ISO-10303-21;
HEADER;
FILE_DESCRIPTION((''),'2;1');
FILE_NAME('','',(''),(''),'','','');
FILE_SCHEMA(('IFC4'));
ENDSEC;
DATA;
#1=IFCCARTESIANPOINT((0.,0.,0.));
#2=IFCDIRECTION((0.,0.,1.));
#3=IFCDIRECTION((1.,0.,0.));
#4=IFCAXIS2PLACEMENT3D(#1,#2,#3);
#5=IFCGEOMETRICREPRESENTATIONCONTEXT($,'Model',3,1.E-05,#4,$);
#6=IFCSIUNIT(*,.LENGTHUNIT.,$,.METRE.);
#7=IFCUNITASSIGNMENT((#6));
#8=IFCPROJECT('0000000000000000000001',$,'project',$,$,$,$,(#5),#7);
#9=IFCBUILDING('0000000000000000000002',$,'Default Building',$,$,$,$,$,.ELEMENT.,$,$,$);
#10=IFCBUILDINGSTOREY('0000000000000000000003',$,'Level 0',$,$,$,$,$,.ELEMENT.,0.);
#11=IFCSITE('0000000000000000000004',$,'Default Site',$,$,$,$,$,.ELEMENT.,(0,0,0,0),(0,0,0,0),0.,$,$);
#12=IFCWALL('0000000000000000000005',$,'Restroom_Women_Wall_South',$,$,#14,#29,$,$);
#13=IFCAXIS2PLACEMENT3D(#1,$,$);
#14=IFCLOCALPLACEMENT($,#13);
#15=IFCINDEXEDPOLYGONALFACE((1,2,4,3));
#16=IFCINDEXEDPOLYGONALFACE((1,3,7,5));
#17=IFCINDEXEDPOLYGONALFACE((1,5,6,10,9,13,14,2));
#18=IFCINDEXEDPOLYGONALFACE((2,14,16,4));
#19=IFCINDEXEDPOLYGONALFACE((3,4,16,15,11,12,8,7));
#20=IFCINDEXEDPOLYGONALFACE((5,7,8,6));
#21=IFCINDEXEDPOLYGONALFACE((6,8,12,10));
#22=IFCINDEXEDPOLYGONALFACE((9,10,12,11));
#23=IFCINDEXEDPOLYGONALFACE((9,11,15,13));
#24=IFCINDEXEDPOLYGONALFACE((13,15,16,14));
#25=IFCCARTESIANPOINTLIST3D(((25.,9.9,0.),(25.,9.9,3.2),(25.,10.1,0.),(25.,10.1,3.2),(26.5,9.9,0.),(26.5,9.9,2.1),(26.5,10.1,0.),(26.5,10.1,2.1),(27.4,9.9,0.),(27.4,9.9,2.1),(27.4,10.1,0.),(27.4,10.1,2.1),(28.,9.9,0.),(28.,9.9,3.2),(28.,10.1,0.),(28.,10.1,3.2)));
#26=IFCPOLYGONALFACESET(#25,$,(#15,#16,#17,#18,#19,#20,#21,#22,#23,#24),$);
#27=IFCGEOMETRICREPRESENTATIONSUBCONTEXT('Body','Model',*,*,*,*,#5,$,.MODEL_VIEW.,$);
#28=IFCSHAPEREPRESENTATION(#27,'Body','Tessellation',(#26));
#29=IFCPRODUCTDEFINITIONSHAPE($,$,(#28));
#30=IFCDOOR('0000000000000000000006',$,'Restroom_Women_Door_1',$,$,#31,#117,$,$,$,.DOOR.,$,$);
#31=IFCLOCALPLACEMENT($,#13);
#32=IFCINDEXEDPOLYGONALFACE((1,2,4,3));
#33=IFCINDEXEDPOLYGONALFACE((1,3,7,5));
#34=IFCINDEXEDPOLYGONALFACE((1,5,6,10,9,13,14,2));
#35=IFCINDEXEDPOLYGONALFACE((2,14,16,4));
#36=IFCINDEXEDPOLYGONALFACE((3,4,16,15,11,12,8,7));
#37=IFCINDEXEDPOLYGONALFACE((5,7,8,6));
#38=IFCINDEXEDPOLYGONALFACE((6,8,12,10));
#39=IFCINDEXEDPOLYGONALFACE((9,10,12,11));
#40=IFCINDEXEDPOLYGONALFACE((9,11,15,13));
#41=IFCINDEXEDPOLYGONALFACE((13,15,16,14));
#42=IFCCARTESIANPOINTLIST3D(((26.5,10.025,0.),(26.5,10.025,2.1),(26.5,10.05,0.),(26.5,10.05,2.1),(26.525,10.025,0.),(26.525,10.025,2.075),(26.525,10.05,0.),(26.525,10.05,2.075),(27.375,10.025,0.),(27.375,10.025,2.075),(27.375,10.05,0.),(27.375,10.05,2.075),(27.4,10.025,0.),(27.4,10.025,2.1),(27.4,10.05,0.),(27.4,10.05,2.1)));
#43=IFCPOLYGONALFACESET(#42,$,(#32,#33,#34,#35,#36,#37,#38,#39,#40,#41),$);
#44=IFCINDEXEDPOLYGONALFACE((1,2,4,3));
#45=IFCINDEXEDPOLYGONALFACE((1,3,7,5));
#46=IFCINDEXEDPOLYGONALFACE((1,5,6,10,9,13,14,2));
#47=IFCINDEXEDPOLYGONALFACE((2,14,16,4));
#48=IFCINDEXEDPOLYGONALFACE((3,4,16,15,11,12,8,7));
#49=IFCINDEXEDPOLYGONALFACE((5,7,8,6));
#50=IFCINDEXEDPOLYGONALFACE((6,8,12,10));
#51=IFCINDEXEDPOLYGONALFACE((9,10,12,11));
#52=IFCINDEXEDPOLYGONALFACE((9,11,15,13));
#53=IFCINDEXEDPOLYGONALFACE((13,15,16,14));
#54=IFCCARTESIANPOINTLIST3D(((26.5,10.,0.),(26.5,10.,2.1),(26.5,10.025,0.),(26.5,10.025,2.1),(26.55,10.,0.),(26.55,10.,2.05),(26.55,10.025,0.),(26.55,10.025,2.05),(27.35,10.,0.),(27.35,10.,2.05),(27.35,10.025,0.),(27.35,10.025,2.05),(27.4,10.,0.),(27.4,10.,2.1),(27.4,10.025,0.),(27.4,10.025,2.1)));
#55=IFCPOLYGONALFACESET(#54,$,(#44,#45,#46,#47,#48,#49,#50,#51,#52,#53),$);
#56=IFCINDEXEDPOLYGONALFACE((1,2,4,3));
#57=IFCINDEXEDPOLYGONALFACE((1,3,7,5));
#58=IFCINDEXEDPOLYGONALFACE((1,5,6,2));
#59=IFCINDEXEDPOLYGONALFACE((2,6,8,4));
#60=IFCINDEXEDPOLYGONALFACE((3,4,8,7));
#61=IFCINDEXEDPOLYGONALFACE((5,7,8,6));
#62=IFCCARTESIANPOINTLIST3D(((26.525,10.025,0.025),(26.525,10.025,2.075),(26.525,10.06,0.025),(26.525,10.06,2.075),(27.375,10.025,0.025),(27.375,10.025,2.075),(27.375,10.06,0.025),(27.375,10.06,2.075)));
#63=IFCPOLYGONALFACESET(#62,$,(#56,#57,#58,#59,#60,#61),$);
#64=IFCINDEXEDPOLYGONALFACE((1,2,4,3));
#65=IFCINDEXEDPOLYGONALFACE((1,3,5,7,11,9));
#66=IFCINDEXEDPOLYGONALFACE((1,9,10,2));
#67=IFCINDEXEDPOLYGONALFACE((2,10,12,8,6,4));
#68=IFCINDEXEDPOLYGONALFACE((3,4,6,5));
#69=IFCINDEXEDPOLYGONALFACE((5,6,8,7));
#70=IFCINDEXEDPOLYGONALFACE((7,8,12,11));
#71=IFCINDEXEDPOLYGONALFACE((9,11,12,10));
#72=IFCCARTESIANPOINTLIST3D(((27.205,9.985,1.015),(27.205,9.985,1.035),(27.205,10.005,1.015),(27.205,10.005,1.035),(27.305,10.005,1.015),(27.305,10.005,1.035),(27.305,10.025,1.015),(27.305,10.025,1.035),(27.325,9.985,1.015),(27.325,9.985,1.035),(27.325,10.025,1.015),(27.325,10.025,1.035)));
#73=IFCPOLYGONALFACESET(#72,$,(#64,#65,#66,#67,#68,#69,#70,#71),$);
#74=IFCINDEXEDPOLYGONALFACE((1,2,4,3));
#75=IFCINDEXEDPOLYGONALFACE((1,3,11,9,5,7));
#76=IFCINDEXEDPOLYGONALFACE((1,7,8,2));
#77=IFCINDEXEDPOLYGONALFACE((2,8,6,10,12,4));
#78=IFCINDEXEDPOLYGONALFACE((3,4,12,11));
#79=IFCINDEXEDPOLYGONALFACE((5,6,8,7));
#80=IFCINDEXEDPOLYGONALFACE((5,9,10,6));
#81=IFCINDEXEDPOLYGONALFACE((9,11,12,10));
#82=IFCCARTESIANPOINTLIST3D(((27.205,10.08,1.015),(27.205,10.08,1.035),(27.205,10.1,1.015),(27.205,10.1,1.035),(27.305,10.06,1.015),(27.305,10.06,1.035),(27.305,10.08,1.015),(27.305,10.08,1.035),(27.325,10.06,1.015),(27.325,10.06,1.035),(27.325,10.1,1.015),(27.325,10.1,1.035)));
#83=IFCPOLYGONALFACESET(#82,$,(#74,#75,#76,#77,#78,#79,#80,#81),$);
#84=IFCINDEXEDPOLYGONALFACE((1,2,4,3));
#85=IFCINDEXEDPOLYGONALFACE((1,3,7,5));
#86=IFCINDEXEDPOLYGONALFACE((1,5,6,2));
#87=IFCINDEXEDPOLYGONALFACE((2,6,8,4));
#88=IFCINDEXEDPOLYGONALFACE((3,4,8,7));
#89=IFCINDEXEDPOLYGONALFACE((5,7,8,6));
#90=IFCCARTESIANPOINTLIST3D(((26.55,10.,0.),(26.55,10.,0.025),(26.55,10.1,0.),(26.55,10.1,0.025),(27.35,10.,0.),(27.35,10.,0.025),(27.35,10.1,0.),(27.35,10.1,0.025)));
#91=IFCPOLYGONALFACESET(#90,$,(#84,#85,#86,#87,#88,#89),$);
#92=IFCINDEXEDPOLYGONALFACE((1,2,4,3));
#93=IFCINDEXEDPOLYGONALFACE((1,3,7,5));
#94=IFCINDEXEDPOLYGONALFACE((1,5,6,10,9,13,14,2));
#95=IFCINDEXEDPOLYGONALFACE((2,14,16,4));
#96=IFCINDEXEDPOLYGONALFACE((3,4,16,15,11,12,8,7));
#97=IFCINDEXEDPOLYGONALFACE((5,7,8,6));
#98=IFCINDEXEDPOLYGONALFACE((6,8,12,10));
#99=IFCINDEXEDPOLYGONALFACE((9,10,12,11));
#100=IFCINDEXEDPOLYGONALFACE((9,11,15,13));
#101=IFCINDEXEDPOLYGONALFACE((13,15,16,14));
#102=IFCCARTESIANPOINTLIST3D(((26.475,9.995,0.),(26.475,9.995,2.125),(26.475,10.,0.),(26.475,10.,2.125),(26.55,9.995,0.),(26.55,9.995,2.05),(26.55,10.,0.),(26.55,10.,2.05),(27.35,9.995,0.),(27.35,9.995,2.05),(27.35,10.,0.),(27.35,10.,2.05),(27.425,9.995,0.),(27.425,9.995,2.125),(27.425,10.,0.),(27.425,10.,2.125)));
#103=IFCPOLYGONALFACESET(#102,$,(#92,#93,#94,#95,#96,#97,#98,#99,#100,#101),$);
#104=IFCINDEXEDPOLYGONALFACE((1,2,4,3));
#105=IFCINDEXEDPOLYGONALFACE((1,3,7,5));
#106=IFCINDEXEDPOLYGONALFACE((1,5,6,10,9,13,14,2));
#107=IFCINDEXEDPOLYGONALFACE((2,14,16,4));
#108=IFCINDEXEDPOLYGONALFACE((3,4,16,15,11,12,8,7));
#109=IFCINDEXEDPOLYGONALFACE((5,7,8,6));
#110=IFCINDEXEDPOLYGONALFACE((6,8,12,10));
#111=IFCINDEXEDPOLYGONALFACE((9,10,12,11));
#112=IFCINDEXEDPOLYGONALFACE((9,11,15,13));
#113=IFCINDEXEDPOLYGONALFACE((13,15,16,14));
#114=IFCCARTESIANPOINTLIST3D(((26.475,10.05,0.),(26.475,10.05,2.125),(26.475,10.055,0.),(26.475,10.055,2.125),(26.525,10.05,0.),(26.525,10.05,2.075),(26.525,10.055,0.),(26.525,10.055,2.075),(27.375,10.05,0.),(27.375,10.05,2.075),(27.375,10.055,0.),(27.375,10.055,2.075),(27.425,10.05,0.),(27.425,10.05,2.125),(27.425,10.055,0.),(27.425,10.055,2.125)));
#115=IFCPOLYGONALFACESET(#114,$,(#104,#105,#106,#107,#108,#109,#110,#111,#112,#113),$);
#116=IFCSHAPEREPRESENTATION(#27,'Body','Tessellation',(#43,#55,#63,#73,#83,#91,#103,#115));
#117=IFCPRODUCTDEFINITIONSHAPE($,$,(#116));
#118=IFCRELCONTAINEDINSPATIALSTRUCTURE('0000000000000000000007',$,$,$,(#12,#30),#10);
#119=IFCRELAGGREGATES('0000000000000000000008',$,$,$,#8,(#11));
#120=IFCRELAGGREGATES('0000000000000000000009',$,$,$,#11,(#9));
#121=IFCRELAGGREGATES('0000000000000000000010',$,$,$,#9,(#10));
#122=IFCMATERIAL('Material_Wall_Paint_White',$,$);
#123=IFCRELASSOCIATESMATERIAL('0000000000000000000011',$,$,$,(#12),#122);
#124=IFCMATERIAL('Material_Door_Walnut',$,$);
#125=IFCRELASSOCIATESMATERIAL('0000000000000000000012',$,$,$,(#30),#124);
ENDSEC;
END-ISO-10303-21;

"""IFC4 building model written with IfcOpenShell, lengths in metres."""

from ifc_helpers import new_model, si_unit, frame, origin_with_axes, place, context, subcontext, project, spatial, line, indexed_curve, outline, extrude, material, element, fill, save


model = new_model("IFC4")

# Units and contexts
model_context = context("Model", 3, precision=1e-05, world=origin_with_axes())
body_context = subcontext(model_context, "Body", "Model", "MODEL_VIEW")
ifc_project = project(units=[si_unit("LENGTHUNIT", "METRE")], contexts=[model_context])

# Site, building, storey
site = spatial("IfcSite", under=ifc_project, Name="Default Site", CompositionType="ELEMENT", RefLatitude=(0, 0, 0, 0), RefLongitude=(0, 0, 0, 0), RefElevation=0.0)
building = spatial("IfcBuilding", under=site, Name="Default Building", CompositionType="ELEMENT")
storey = spatial("IfcBuildingStorey", under=building, Name="Level 0", CompositionType="ELEMENT", Elevation=0.0)

# Shared definitions
ifc_material_1 = material(Name="Material_Wall_Paint_White")

# Shared definitions
ifc_material_2 = material(Name="Material_Door_Walnut")

# Wall, opening, door
wall_1_placement = place(None, frame((25.0, 10.0, 0.0), z_axis=(0.0, 0.0, 1.0), x_axis=(1.0, 0.0, 0.0)))
wall_1 = element("IfcWall", 1, at=wall_1_placement, inside=storey, material=ifc_material_1, Name="Restroom_Women_Wall_South", context=body_context, shape_type="SweptSolid", body=[
    extrude(outline(indexed_curve([(0.0, 0.0), (0.0, 0.2), (3.0, 0.2), (3.0, 0.0), (0.0, 0.0)], self_intersect=False)), frame((0.0, -0.1, 0.0), z_axis=(0.0, 0.0, 1.0), x_axis=(1.0, 0.0, 0.0)), (0.0, 0.0, 1.0), 3.2),
])
opening_1_placement = place(wall_1_placement, frame((1.5, -0.5, 0.0), z_axis=(0.0, 0.0, 1.0), x_axis=(1.0, 0.0, 0.0)))
opening_1 = element("IfcOpeningElement", 2, at=opening_1_placement, inside=storey, cuts=wall_1, PredefinedType="OPENING", context=body_context, shape_type="SweptSolid", body=[
    extrude(outline(indexed_curve([(0.0, 0.0), (0.0, 1.0), (0.9, 1.0), (0.9, 0.0), (0.0, 0.0)], self_intersect=False)), origin_with_axes(), (0.0, 0.0, 1.0), 2.1),
])
door_1_placement = place(None, frame((26.5, 10.0, 0.0), z_axis=(0.0, 0.0, 1.0), x_axis=(1.0, 0.0, 0.0)))
door_1 = element("IfcDoor", 3, at=door_1_placement, inside=storey, material=ifc_material_2, Name="Restroom_Women_Door_1", PredefinedType="DOOR", context=body_context, shape_type="SweptSolid", body=[
    extrude(outline(indexed_curve([(0.0, 0.0), (0.0, 2.1), (0.9, 2.1), (0.9, 0.0), (0.875, 0.0), (0.875, 2.075), (0.025, 2.075), (0.025, 0.0)], segments=[line(1, 2, 3, 4, 5, 6, 7, 8, 1)])), frame((0.0, 0.025, 0.0), z_axis=(0.0, -1.0, 0.0), x_axis=(1.0, 0.0, 0.0)), (0.0, 0.0, -1.0), 0.025),
    extrude(outline(indexed_curve([(0.0, 0.0), (0.0, 2.1), (0.9, 2.1), (0.9, 0.0), (0.85, 0.0), (0.85, 2.05), (0.05, 2.05), (0.05, 0.0)], segments=[line(1, 2, 3, 4, 5, 6, 7, 8, 1)])), frame((0.0, 0.0, 0.0), z_axis=(0.0, -1.0, 0.0), x_axis=(1.0, 0.0, 0.0)), (0.0, 0.0, -1.0), 0.025),
    extrude(outline(indexed_curve([(0.0, 0.0), (0.85, 0.0), (0.85, 0.035), (0.0, 0.035)], segments=[line(1, 2, 3, 4, 1)])), frame((0.025, 0.025, 0.025), z_axis=(0.0, 0.0, 1.0), x_axis=(1.0, 0.0, 0.0)), (0.0, 0.0, 1.0), 2.05),
    extrude(outline(indexed_curve([(0.0, 0.0), (0.0, -0.04), (-0.12, -0.04), (-0.12, -0.02), (-0.02, -0.02), (-0.02, 0.0)], segments=[line(1, 2, 3, 4, 5, 6, 1)])), frame((0.825, 0.025, 1.015), z_axis=(0.0, 0.0, 1.0), x_axis=(1.0, 0.0, 0.0)), (0.0, 0.0, 1.0), 0.02),
    extrude(outline(indexed_curve([(0.0, 0.0), (0.0, 0.04), (-0.12, 0.04), (-0.12, 0.02), (-0.02, 0.02), (-0.02, 0.0)], segments=[line(1, 2, 3, 4, 5, 6, 1)])), frame((0.825, 0.06, 1.015), z_axis=(0.0, 0.0, 1.0), x_axis=(1.0, 0.0, 0.0)), (0.0, 0.0, 1.0), 0.02),
    extrude(outline(indexed_curve([(0.0, 0.0), (0.8, 0.0), (0.8, 0.1), (0.0, 0.1)], segments=[line(1, 2, 3, 4, 1)])), frame((0.05, 0.0, 0.0), z_axis=(0.0, 0.0, 1.0), x_axis=(1.0, 0.0, 0.0)), (0.0, 0.0, 1.0), 0.025),
    extrude(outline(indexed_curve([(0.0, 0.0), (0.0, 2.125), (0.95, 2.125), (0.95, 0.0), (0.875, 0.0), (0.875, 2.05), (0.075, 2.05), (0.075, 0.0)], segments=[line(1, 2, 3, 4, 5, 6, 7, 8, 1)])), frame((-0.025, -0.005, 0.0), z_axis=(0.0, -1.0, 0.0), x_axis=(1.0, 0.0, 0.0)), (0.0, 0.0, -1.0), 0.005),
    extrude(outline(indexed_curve([(0.0, 0.0), (0.0, 2.125), (0.95, 2.125), (0.95, 0.0), (0.9, 0.0), (0.9, 2.075), (0.05, 2.075), (0.05, 0.0)], segments=[line(1, 2, 3, 4, 5, 6, 7, 8, 1)])), frame((-0.025, 0.05, 0.0), z_axis=(0.0, -1.0, 0.0), x_axis=(1.0, 0.0, 0.0)), (0.0, 0.0, -1.0), 0.005),
])
fill(opening_1, door_1)

save(model, "model.ifc")
